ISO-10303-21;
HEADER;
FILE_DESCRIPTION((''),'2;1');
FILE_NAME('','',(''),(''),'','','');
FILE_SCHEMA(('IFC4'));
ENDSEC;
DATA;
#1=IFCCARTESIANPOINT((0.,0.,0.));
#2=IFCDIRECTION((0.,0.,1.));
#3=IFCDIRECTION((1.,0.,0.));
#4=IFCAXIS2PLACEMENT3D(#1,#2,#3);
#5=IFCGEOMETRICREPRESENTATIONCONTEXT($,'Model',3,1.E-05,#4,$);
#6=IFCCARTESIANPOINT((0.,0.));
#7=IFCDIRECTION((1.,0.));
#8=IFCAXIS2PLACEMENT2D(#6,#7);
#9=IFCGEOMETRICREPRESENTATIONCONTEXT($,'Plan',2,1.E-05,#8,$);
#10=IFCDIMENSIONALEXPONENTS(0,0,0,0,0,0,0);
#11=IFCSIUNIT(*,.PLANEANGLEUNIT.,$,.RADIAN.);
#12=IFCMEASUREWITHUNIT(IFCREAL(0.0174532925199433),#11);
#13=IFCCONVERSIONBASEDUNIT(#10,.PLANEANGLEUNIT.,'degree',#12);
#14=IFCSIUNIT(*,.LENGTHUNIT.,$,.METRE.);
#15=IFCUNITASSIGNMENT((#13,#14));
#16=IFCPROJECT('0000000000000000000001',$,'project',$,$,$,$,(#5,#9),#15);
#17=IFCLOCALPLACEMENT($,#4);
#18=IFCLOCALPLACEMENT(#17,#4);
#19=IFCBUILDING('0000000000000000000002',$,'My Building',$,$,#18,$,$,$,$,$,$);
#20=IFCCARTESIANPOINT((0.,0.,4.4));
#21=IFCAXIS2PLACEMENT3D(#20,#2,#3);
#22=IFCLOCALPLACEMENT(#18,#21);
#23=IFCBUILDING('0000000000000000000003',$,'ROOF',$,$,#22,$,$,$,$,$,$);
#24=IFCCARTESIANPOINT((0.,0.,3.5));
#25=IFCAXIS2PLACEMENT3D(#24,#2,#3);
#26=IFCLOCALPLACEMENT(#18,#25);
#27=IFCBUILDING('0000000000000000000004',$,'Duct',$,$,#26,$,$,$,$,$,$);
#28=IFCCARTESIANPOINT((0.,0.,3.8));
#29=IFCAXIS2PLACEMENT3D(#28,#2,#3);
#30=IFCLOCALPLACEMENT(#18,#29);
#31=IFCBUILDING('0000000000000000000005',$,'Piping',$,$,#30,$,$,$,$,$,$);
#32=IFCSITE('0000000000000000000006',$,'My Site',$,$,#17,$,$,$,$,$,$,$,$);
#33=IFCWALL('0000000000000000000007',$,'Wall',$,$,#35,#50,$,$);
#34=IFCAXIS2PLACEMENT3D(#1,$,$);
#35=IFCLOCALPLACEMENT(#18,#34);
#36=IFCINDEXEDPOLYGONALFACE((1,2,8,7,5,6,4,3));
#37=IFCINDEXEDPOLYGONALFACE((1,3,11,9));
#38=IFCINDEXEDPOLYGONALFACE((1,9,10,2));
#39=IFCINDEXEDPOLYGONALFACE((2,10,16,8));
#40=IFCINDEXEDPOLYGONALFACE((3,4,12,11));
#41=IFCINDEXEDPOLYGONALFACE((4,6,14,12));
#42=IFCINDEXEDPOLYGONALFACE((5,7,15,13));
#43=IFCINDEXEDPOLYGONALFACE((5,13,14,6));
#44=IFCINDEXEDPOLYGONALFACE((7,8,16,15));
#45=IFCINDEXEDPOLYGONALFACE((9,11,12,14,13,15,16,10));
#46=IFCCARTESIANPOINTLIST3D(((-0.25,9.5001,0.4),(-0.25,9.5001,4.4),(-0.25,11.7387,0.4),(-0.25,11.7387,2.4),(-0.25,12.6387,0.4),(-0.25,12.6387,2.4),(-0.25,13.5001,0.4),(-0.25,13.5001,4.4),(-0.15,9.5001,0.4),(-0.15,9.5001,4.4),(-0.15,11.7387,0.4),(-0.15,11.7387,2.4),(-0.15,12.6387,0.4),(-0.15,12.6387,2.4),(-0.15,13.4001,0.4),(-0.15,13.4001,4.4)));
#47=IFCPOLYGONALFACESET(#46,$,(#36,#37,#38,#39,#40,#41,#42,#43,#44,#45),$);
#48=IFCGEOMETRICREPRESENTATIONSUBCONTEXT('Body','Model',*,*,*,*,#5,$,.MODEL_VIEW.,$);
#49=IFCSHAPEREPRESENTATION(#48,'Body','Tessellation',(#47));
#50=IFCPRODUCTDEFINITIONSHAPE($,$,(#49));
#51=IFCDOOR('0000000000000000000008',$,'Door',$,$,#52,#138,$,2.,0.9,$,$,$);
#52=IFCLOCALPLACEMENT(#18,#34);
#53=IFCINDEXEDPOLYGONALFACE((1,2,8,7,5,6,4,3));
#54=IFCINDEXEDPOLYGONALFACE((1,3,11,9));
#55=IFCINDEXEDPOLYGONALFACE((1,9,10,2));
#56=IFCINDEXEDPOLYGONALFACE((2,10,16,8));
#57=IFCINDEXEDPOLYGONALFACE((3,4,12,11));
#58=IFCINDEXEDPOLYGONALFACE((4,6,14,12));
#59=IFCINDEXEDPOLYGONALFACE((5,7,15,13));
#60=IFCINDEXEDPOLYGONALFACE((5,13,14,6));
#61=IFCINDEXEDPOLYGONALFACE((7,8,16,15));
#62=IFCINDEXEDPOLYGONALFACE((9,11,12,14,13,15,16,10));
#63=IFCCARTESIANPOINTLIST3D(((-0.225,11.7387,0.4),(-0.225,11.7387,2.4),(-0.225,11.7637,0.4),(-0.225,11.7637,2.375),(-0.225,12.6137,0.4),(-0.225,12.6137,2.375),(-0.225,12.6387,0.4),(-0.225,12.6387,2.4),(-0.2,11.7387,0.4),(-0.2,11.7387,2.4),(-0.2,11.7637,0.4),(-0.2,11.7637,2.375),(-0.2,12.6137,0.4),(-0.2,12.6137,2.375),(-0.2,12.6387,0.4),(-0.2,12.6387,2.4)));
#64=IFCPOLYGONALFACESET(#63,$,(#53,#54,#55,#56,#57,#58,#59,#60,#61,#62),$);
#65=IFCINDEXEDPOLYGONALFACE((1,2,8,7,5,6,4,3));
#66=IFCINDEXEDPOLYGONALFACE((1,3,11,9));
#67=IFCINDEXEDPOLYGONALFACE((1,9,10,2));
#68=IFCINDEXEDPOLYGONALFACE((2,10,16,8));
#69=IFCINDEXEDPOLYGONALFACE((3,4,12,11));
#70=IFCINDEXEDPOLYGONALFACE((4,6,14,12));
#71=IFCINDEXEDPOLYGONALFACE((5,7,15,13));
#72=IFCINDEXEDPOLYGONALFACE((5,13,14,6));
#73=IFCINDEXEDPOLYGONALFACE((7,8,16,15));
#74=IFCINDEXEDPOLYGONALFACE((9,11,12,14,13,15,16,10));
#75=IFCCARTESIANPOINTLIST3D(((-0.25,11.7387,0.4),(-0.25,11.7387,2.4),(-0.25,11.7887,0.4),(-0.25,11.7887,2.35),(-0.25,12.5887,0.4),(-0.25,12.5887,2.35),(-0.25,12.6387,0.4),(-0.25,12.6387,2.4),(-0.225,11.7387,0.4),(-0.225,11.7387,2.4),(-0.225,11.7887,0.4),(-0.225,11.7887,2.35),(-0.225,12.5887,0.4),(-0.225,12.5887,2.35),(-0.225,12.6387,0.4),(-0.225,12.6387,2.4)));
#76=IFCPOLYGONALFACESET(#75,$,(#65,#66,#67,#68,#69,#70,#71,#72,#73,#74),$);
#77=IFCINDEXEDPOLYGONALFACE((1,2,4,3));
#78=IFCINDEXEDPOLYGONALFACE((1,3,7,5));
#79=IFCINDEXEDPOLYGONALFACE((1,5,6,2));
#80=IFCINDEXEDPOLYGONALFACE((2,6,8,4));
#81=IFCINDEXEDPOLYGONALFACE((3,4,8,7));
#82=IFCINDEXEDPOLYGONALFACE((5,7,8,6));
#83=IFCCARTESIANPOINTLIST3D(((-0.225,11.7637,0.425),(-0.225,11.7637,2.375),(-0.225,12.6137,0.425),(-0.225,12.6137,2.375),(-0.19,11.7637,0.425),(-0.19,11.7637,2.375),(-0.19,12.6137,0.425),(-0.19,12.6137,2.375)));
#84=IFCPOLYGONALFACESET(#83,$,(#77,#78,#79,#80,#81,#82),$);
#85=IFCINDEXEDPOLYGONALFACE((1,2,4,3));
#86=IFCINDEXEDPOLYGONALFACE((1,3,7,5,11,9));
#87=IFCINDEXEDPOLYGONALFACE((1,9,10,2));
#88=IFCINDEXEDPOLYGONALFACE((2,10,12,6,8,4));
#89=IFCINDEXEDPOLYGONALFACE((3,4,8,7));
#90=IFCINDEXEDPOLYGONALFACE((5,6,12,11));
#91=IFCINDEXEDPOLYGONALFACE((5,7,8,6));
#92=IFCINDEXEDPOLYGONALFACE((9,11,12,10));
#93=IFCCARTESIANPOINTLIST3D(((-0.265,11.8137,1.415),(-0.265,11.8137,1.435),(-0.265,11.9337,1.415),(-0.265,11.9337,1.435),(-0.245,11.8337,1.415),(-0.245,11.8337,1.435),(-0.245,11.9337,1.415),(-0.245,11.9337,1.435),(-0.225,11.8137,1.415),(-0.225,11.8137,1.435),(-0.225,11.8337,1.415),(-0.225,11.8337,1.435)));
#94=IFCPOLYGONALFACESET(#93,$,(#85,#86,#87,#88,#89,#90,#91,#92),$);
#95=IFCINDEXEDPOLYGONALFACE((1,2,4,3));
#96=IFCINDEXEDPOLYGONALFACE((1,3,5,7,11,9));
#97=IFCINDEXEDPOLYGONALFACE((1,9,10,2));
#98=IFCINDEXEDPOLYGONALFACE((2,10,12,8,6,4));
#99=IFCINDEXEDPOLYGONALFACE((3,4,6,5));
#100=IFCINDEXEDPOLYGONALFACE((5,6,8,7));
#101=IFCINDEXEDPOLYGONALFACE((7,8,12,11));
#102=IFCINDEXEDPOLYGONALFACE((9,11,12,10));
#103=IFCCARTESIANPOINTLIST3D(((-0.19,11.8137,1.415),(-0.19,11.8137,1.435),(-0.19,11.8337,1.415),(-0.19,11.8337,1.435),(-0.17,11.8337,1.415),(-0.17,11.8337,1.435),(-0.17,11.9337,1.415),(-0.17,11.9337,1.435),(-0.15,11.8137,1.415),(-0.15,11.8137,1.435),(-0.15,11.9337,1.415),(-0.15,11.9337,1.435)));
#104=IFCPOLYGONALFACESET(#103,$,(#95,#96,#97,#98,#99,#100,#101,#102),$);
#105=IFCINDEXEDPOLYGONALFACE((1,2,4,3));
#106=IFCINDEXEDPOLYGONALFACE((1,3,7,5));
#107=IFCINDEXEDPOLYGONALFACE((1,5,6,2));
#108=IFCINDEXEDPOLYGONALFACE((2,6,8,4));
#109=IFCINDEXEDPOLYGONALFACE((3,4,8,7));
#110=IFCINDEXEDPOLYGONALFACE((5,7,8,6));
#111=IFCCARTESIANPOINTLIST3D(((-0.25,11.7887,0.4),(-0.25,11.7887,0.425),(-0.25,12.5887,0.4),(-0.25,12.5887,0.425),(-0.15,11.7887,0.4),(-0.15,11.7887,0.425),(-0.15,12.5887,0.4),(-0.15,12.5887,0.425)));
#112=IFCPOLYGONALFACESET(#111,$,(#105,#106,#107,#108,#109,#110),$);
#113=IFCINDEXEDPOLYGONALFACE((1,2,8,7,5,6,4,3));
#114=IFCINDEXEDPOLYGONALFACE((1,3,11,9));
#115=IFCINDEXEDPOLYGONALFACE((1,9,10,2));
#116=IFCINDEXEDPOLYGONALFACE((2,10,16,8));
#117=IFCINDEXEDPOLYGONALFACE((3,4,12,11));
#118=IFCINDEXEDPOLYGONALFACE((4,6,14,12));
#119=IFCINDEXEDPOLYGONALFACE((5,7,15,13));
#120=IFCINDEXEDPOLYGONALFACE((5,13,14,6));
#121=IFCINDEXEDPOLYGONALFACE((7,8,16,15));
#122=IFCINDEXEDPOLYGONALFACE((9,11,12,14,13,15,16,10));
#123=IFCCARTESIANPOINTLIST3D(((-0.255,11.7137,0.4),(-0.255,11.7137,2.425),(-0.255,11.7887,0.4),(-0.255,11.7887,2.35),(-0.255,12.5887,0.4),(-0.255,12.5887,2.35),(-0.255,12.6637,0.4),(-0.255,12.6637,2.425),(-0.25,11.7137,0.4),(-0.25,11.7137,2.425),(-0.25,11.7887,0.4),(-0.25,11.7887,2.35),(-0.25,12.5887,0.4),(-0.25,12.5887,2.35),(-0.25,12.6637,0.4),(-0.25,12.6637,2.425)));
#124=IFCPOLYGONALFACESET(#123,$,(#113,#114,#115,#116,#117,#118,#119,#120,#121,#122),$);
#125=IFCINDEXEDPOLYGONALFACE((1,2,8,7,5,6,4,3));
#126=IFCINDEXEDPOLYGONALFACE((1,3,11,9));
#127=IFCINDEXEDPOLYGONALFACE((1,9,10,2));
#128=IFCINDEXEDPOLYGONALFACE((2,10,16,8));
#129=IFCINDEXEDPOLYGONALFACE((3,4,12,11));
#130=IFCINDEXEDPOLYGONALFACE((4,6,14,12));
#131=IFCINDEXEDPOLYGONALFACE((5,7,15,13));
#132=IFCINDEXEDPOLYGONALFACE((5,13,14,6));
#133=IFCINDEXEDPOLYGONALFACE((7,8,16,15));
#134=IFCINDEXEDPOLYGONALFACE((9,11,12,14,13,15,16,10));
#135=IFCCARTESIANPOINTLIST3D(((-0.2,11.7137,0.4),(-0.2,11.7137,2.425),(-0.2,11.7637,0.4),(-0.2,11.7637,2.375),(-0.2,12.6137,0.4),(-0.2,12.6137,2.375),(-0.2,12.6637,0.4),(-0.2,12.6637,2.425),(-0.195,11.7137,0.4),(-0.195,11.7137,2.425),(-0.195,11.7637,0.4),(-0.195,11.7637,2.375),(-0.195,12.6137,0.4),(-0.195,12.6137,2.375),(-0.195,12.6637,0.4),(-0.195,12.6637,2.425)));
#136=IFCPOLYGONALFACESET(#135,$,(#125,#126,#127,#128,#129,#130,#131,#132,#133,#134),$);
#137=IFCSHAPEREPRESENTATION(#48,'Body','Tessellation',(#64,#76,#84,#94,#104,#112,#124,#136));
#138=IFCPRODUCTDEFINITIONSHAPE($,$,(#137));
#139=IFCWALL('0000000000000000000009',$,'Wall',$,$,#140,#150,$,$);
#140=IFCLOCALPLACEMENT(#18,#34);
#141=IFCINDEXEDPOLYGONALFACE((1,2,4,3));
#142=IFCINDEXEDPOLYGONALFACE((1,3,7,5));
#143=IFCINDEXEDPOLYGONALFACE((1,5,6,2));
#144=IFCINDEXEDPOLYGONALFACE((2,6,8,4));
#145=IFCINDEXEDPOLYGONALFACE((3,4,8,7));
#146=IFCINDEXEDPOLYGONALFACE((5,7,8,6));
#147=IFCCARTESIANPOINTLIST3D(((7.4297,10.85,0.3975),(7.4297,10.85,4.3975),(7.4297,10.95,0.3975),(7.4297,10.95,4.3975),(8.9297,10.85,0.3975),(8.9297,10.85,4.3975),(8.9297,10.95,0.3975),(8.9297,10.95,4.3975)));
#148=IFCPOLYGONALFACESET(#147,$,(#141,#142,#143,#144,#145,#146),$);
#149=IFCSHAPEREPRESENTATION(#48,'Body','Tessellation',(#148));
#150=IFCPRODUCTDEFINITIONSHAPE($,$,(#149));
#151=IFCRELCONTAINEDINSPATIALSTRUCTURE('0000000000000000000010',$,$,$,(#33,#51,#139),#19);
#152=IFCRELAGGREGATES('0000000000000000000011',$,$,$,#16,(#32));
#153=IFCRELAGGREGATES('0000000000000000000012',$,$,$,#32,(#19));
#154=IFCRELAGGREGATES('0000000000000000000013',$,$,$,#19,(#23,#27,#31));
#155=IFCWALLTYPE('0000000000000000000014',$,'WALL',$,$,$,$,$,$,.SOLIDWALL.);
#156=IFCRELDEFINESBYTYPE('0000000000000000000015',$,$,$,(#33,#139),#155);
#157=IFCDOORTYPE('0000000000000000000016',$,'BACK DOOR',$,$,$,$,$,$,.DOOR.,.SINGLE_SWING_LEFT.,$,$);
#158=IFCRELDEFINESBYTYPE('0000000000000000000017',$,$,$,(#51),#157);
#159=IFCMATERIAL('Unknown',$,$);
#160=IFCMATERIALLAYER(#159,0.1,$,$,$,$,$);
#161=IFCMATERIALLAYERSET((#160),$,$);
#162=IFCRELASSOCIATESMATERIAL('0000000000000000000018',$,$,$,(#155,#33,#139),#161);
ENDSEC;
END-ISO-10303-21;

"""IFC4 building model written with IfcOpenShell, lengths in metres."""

from ifc_helpers import new_model, entity, si_unit, converted_unit, frame, origin_with_axes, origin_2d_with_axis, place, context, subcontext, project, spatial, line, indexed_curve, outline, extrude, shape, source, transform, mapped, material, layer, layer_set, layer_usage, type_object, type_shapes, element, fill, save


model = new_model("IFC4")

# Units and contexts
model_context = context("Model", 3, precision=1e-05, world=origin_with_axes())
plan_context = context("Plan", 2, precision=1e-05, world=origin_2d_with_axis())
body_context_1 = subcontext(model_context, "Body", "Model", "MODEL_VIEW")
body_context_2 = subcontext(plan_context, "Body", "Plan", "PLAN_VIEW")
ifc_project = project(units=[converted_unit("PLANEANGLEUNIT", "degree", entity("IfcReal", 0.0174532925199433), si_unit("PLANEANGLEUNIT", "RADIAN"), dimensions=[0, 0, 0, 0, 0, 0, 0]), si_unit("LENGTHUNIT", "METRE")], contexts=[model_context, plan_context])

# Site, building
site_placement = place(None, origin_with_axes())
site = spatial("IfcSite", under=ifc_project, at=site_placement, Name="My Site")
building_1_placement = place(site_placement, origin_with_axes())
building_1 = spatial("IfcBuilding", under=site, at=building_1_placement, Name="My Building")

# Shared definitions
ifc_material = material(Name="Unknown")

# Shared definitions
building_2_placement = place(building_1_placement, frame((0.0, 0.0, 4.4), z_axis=(0.0, 0.0, 1.0), x_axis=(1.0, 0.0, 0.0)))
building_2 = spatial("IfcBuilding", under=building_1, at=building_2_placement, Name="ROOF")

# Wall, opening, door
ifc_layer_1 = layer(ifc_material, 0.1)
ifc_layer_set_1 = layer_set([ifc_layer_1])
ifc_layer_usage_1 = layer_usage(ifc_layer_set_1, "AXIS2", "POSITIVE", 0.0)
wall_type_1 = type_object("IfcWallType", Name="WALL", PredefinedType="SOLIDWALL", material=ifc_layer_set_1)
wall_1_placement = place(building_1_placement, frame((-0.25, 13.5001, 0.4), z_axis=(0.0, 0.0, 1.0), x_axis=(0.0, -1.0, 0.0)))
wall_1 = element("IfcWall", 1, at=wall_1_placement, inside=building_1, type_object=wall_type_1, material=ifc_layer_usage_1, Name="Wall", context=body_context_1, shape_type="SweptSolid", body=[
    extrude(outline(indexed_curve([(0.0, 0.0), (0.1, 0.1), (4.0, 0.1), (4.0, 0.0)], segments=[line(1, 2, 3, 4, 1)])), origin_with_axes(), (0.0, 0.0, 1.0), 4.0),
])
shared_shape_1 = source(origin_with_axes(), body_context_1, "Body", "SweptSolid", [
    extrude(outline(indexed_curve([(0.0, 0.0), (0.9, 0.0), (0.9, 2.0), (0.0, 2.0)], segments=[line(1, 2, 3, 4, 1)])), frame((0.0, -0.6, 0.0), z_axis=(0.0, -1.0, 0.0), x_axis=(1.0, 0.0, 0.0)), (0.0, 0.0, -1.0), 1.2),
])
opening_1_placement = place(wall_1_placement, frame((0.8613, 0.0, 0.0), z_axis=(0.0, 0.0, 1.0), x_axis=(1.0, 0.0, 0.0)))
opening_1 = element("IfcOpeningElement", 2, at=opening_1_placement, cuts=wall_1, PredefinedType="OPENING", context=body_context_1, shape_type="MappedRepresentation", body=[
    mapped(shared_shape_1, transform((0.0, 0.0, 0.0), x_axis=(1.0, 0.0, 0.0), y_axis=(0.0, 1.0, 0.0), z_axis=(0.0, 0.0, 1.0), scale=1.0)),
])
door_type = type_object("IfcDoorType", Name="BACK DOOR", OperationType="SINGLE_SWING_LEFT", PredefinedType="DOOR")
shared_shape_2 = source(origin_with_axes(), body_context_1, "Body", "SweptSolid", [
    extrude(outline(indexed_curve([(0.0, 0.0), (0.0, 2.0), (0.9, 2.0), (0.9, 0.0), (0.875, 0.0), (0.875, 1.975), (0.025, 1.975), (0.025, 0.0)], segments=[line(1, 2, 3, 4, 5, 6, 7, 8, 1)])), frame((0.0, 0.025, 0.0), z_axis=(0.0, -1.0, 0.0), x_axis=(1.0, 0.0, 0.0)), (0.0, 0.0, -1.0), 0.025),
    extrude(outline(indexed_curve([(0.0, 0.0), (0.0, 2.0), (0.9, 2.0), (0.9, 0.0), (0.85, 0.0), (0.85, 1.95), (0.05, 1.95), (0.05, 0.0)], segments=[line(1, 2, 3, 4, 5, 6, 7, 8, 1)])), frame((0.0, 0.0, 0.0), z_axis=(0.0, -1.0, 0.0), x_axis=(1.0, 0.0, 0.0)), (0.0, 0.0, -1.0), 0.025),
    extrude(outline(indexed_curve([(0.0, 0.0), (0.85, 0.0), (0.85, 0.035), (0.0, 0.035)], segments=[line(1, 2, 3, 4, 1)])), frame((0.025, 0.025, 0.025), z_axis=(0.0, 0.0, 1.0), x_axis=(1.0, 0.0, 0.0)), (0.0, 0.0, 1.0), 1.95),
    extrude(outline(indexed_curve([(0.0, 0.0), (0.0, -0.04), (-0.12, -0.04), (-0.12, -0.02), (-0.02, -0.02), (-0.02, 0.0)], segments=[line(1, 2, 3, 4, 5, 6, 1)])), frame((0.825, 0.025, 1.015), z_axis=(0.0, 0.0, 1.0), x_axis=(1.0, 0.0, 0.0)), (0.0, 0.0, 1.0), 0.02),
    extrude(outline(indexed_curve([(0.0, 0.0), (0.0, 0.04), (-0.12, 0.04), (-0.12, 0.02), (-0.02, 0.02), (-0.02, 0.0)], segments=[line(1, 2, 3, 4, 5, 6, 1)])), frame((0.825, 0.06, 1.015), z_axis=(0.0, 0.0, 1.0), x_axis=(1.0, 0.0, 0.0)), (0.0, 0.0, 1.0), 0.02),
    extrude(outline(indexed_curve([(0.0, 0.0), (0.8, 0.0), (0.8, 0.1), (0.0, 0.1)], segments=[line(1, 2, 3, 4, 1)])), frame((0.05, 0.0, 0.0), z_axis=(0.0, 0.0, 1.0), x_axis=(1.0, 0.0, 0.0)), (0.0, 0.0, 1.0), 0.025),
    extrude(outline(indexed_curve([(0.0, 0.0), (0.0, 2.025), (0.95, 2.025), (0.95, 0.0), (0.875, 0.0), (0.875, 1.95), (0.075, 1.95), (0.075, 0.0)], segments=[line(1, 2, 3, 4, 5, 6, 7, 8, 1)])), frame((-0.025, -0.005, 0.0), z_axis=(0.0, -1.0, 0.0), x_axis=(1.0, 0.0, 0.0)), (0.0, 0.0, -1.0), 0.005),
    extrude(outline(indexed_curve([(0.0, 0.0), (0.0, 2.025), (0.95, 2.025), (0.95, 0.0), (0.9, 0.0), (0.9, 1.975), (0.05, 1.975), (0.05, 0.0)], segments=[line(1, 2, 3, 4, 5, 6, 7, 8, 1)])), frame((-0.025, 0.05, 0.0), z_axis=(0.0, -1.0, 0.0), x_axis=(1.0, 0.0, 0.0)), (0.0, 0.0, -1.0), 0.005),
])
shared_shape_3 = source(origin_with_axes(), body_context_2, "Body", "Curve2D", [
    entity("IfcIndexedPolyCurve", entity("IfcCartesianPointList2D", [[0.0, 0.0], [0.0, 0.05], [0.025, 0.05], [0.025, 0.025], [0.05, 0.025], [0.05, 0.0]]), [entity("IfcLineIndex", [1, 2, 3, 4, 5, 6, 1])]),
    entity("IfcIndexedPolyCurve", entity("IfcCartesianPointList2D", [[0.9, 0.0], [0.9, 0.05], [0.875, 0.05], [0.875, 0.025], [0.85, 0.025], [0.85, 0.0]]), [entity("IfcLineIndex", [1, 2, 3, 4, 5, 6, 1])]),
    entity("IfcTrimmedCurve", entity("IfcEllipse", entity("IfcAxis2Placement2D", entity("IfcCartesianPoint", [0.06, 0.05]), entity("IfcDirection", [1.0, 0.0])), 0.815, 0.85), [entity("IfcCartesianPoint", [0.875, 0.05])], [entity("IfcCartesianPoint", [0.06, 0.9])], True, "CARTESIAN"),
    entity("IfcIndexedPolyCurve", entity("IfcCartesianPointList2D", [[0.025, 0.05], [0.06, 0.05], [0.06, 0.9], [0.025, 0.9]]), [entity("IfcLineIndex", [1, 2, 3, 4, 1])]),
])
type_shapes(door_type, [shared_shape_2, shared_shape_3])
door_1_placement = place(opening_1_placement, frame((0.0, 0.0, 0.0), z_axis=(0.0, 0.0, 1.0), x_axis=(1.0, 0.0, 0.0)))
door_1 = element("IfcDoor", 3, at=door_1_placement, inside=building_1, type_object=door_type, Name="Door", OverallHeight=2.0, OverallWidth=0.9, shapes=[
    shape(body_context_1, "Body", "MappedRepresentation", [mapped(shared_shape_2, transform((0.0, 0.0, 0.0), x_axis=(1.0, 0.0, 0.0), y_axis=(0.0, 1.0, 0.0), z_axis=(0.0, 0.0, 1.0), scale=1.0))]),
    shape(body_context_2, "Body", "MappedRepresentation", [mapped(shared_shape_3, transform((0.0, 0.0, 0.0), x_axis=(1.0, 0.0, 0.0), y_axis=(0.0, 1.0, 0.0), z_axis=(0.0, 0.0, 1.0), scale=1.0))]),
])
fill(opening_1, door_1)

# Wall
ifc_layer_usage_2 = layer_usage(ifc_layer_set_1, "AXIS2", "POSITIVE", 0.0)
wall_2_placement = place(building_1_placement, frame((8.9297, 10.95, 0.3975), z_axis=(0.0, 0.0, 1.0), x_axis=(-1.0, 0.0, 0.0)))
element("IfcWall", 4, at=wall_2_placement, inside=building_1, type_object=wall_type_1, material=ifc_layer_usage_2, Name="Wall", context=body_context_1, shape_type="SweptSolid", body=[
    extrude(outline(indexed_curve([(0.0, 0.0), (0.0, 0.1), (1.5, 0.1), (1.5, 0.0)], segments=[line(1, 2, 3, 4, 1)])), origin_with_axes(), (0.0, 0.0, 1.0), 4.0),
])

# Shared definitions
building_3_placement = place(building_1_placement, frame((0.0, 0.0, 3.5), z_axis=(0.0, 0.0, 1.0), x_axis=(1.0, 0.0, 0.0)))
building_3 = spatial("IfcBuilding", under=building_1, at=building_3_placement, Name="Duct")

# Shared definitions
building_4_placement = place(building_1_placement, frame((0.0, 0.0, 3.8), z_axis=(0.0, 0.0, 1.0), x_axis=(1.0, 0.0, 0.0)))
building_4 = spatial("IfcBuilding", under=building_1, at=building_4_placement, Name="Piping")

save(model, "model.ifc")
